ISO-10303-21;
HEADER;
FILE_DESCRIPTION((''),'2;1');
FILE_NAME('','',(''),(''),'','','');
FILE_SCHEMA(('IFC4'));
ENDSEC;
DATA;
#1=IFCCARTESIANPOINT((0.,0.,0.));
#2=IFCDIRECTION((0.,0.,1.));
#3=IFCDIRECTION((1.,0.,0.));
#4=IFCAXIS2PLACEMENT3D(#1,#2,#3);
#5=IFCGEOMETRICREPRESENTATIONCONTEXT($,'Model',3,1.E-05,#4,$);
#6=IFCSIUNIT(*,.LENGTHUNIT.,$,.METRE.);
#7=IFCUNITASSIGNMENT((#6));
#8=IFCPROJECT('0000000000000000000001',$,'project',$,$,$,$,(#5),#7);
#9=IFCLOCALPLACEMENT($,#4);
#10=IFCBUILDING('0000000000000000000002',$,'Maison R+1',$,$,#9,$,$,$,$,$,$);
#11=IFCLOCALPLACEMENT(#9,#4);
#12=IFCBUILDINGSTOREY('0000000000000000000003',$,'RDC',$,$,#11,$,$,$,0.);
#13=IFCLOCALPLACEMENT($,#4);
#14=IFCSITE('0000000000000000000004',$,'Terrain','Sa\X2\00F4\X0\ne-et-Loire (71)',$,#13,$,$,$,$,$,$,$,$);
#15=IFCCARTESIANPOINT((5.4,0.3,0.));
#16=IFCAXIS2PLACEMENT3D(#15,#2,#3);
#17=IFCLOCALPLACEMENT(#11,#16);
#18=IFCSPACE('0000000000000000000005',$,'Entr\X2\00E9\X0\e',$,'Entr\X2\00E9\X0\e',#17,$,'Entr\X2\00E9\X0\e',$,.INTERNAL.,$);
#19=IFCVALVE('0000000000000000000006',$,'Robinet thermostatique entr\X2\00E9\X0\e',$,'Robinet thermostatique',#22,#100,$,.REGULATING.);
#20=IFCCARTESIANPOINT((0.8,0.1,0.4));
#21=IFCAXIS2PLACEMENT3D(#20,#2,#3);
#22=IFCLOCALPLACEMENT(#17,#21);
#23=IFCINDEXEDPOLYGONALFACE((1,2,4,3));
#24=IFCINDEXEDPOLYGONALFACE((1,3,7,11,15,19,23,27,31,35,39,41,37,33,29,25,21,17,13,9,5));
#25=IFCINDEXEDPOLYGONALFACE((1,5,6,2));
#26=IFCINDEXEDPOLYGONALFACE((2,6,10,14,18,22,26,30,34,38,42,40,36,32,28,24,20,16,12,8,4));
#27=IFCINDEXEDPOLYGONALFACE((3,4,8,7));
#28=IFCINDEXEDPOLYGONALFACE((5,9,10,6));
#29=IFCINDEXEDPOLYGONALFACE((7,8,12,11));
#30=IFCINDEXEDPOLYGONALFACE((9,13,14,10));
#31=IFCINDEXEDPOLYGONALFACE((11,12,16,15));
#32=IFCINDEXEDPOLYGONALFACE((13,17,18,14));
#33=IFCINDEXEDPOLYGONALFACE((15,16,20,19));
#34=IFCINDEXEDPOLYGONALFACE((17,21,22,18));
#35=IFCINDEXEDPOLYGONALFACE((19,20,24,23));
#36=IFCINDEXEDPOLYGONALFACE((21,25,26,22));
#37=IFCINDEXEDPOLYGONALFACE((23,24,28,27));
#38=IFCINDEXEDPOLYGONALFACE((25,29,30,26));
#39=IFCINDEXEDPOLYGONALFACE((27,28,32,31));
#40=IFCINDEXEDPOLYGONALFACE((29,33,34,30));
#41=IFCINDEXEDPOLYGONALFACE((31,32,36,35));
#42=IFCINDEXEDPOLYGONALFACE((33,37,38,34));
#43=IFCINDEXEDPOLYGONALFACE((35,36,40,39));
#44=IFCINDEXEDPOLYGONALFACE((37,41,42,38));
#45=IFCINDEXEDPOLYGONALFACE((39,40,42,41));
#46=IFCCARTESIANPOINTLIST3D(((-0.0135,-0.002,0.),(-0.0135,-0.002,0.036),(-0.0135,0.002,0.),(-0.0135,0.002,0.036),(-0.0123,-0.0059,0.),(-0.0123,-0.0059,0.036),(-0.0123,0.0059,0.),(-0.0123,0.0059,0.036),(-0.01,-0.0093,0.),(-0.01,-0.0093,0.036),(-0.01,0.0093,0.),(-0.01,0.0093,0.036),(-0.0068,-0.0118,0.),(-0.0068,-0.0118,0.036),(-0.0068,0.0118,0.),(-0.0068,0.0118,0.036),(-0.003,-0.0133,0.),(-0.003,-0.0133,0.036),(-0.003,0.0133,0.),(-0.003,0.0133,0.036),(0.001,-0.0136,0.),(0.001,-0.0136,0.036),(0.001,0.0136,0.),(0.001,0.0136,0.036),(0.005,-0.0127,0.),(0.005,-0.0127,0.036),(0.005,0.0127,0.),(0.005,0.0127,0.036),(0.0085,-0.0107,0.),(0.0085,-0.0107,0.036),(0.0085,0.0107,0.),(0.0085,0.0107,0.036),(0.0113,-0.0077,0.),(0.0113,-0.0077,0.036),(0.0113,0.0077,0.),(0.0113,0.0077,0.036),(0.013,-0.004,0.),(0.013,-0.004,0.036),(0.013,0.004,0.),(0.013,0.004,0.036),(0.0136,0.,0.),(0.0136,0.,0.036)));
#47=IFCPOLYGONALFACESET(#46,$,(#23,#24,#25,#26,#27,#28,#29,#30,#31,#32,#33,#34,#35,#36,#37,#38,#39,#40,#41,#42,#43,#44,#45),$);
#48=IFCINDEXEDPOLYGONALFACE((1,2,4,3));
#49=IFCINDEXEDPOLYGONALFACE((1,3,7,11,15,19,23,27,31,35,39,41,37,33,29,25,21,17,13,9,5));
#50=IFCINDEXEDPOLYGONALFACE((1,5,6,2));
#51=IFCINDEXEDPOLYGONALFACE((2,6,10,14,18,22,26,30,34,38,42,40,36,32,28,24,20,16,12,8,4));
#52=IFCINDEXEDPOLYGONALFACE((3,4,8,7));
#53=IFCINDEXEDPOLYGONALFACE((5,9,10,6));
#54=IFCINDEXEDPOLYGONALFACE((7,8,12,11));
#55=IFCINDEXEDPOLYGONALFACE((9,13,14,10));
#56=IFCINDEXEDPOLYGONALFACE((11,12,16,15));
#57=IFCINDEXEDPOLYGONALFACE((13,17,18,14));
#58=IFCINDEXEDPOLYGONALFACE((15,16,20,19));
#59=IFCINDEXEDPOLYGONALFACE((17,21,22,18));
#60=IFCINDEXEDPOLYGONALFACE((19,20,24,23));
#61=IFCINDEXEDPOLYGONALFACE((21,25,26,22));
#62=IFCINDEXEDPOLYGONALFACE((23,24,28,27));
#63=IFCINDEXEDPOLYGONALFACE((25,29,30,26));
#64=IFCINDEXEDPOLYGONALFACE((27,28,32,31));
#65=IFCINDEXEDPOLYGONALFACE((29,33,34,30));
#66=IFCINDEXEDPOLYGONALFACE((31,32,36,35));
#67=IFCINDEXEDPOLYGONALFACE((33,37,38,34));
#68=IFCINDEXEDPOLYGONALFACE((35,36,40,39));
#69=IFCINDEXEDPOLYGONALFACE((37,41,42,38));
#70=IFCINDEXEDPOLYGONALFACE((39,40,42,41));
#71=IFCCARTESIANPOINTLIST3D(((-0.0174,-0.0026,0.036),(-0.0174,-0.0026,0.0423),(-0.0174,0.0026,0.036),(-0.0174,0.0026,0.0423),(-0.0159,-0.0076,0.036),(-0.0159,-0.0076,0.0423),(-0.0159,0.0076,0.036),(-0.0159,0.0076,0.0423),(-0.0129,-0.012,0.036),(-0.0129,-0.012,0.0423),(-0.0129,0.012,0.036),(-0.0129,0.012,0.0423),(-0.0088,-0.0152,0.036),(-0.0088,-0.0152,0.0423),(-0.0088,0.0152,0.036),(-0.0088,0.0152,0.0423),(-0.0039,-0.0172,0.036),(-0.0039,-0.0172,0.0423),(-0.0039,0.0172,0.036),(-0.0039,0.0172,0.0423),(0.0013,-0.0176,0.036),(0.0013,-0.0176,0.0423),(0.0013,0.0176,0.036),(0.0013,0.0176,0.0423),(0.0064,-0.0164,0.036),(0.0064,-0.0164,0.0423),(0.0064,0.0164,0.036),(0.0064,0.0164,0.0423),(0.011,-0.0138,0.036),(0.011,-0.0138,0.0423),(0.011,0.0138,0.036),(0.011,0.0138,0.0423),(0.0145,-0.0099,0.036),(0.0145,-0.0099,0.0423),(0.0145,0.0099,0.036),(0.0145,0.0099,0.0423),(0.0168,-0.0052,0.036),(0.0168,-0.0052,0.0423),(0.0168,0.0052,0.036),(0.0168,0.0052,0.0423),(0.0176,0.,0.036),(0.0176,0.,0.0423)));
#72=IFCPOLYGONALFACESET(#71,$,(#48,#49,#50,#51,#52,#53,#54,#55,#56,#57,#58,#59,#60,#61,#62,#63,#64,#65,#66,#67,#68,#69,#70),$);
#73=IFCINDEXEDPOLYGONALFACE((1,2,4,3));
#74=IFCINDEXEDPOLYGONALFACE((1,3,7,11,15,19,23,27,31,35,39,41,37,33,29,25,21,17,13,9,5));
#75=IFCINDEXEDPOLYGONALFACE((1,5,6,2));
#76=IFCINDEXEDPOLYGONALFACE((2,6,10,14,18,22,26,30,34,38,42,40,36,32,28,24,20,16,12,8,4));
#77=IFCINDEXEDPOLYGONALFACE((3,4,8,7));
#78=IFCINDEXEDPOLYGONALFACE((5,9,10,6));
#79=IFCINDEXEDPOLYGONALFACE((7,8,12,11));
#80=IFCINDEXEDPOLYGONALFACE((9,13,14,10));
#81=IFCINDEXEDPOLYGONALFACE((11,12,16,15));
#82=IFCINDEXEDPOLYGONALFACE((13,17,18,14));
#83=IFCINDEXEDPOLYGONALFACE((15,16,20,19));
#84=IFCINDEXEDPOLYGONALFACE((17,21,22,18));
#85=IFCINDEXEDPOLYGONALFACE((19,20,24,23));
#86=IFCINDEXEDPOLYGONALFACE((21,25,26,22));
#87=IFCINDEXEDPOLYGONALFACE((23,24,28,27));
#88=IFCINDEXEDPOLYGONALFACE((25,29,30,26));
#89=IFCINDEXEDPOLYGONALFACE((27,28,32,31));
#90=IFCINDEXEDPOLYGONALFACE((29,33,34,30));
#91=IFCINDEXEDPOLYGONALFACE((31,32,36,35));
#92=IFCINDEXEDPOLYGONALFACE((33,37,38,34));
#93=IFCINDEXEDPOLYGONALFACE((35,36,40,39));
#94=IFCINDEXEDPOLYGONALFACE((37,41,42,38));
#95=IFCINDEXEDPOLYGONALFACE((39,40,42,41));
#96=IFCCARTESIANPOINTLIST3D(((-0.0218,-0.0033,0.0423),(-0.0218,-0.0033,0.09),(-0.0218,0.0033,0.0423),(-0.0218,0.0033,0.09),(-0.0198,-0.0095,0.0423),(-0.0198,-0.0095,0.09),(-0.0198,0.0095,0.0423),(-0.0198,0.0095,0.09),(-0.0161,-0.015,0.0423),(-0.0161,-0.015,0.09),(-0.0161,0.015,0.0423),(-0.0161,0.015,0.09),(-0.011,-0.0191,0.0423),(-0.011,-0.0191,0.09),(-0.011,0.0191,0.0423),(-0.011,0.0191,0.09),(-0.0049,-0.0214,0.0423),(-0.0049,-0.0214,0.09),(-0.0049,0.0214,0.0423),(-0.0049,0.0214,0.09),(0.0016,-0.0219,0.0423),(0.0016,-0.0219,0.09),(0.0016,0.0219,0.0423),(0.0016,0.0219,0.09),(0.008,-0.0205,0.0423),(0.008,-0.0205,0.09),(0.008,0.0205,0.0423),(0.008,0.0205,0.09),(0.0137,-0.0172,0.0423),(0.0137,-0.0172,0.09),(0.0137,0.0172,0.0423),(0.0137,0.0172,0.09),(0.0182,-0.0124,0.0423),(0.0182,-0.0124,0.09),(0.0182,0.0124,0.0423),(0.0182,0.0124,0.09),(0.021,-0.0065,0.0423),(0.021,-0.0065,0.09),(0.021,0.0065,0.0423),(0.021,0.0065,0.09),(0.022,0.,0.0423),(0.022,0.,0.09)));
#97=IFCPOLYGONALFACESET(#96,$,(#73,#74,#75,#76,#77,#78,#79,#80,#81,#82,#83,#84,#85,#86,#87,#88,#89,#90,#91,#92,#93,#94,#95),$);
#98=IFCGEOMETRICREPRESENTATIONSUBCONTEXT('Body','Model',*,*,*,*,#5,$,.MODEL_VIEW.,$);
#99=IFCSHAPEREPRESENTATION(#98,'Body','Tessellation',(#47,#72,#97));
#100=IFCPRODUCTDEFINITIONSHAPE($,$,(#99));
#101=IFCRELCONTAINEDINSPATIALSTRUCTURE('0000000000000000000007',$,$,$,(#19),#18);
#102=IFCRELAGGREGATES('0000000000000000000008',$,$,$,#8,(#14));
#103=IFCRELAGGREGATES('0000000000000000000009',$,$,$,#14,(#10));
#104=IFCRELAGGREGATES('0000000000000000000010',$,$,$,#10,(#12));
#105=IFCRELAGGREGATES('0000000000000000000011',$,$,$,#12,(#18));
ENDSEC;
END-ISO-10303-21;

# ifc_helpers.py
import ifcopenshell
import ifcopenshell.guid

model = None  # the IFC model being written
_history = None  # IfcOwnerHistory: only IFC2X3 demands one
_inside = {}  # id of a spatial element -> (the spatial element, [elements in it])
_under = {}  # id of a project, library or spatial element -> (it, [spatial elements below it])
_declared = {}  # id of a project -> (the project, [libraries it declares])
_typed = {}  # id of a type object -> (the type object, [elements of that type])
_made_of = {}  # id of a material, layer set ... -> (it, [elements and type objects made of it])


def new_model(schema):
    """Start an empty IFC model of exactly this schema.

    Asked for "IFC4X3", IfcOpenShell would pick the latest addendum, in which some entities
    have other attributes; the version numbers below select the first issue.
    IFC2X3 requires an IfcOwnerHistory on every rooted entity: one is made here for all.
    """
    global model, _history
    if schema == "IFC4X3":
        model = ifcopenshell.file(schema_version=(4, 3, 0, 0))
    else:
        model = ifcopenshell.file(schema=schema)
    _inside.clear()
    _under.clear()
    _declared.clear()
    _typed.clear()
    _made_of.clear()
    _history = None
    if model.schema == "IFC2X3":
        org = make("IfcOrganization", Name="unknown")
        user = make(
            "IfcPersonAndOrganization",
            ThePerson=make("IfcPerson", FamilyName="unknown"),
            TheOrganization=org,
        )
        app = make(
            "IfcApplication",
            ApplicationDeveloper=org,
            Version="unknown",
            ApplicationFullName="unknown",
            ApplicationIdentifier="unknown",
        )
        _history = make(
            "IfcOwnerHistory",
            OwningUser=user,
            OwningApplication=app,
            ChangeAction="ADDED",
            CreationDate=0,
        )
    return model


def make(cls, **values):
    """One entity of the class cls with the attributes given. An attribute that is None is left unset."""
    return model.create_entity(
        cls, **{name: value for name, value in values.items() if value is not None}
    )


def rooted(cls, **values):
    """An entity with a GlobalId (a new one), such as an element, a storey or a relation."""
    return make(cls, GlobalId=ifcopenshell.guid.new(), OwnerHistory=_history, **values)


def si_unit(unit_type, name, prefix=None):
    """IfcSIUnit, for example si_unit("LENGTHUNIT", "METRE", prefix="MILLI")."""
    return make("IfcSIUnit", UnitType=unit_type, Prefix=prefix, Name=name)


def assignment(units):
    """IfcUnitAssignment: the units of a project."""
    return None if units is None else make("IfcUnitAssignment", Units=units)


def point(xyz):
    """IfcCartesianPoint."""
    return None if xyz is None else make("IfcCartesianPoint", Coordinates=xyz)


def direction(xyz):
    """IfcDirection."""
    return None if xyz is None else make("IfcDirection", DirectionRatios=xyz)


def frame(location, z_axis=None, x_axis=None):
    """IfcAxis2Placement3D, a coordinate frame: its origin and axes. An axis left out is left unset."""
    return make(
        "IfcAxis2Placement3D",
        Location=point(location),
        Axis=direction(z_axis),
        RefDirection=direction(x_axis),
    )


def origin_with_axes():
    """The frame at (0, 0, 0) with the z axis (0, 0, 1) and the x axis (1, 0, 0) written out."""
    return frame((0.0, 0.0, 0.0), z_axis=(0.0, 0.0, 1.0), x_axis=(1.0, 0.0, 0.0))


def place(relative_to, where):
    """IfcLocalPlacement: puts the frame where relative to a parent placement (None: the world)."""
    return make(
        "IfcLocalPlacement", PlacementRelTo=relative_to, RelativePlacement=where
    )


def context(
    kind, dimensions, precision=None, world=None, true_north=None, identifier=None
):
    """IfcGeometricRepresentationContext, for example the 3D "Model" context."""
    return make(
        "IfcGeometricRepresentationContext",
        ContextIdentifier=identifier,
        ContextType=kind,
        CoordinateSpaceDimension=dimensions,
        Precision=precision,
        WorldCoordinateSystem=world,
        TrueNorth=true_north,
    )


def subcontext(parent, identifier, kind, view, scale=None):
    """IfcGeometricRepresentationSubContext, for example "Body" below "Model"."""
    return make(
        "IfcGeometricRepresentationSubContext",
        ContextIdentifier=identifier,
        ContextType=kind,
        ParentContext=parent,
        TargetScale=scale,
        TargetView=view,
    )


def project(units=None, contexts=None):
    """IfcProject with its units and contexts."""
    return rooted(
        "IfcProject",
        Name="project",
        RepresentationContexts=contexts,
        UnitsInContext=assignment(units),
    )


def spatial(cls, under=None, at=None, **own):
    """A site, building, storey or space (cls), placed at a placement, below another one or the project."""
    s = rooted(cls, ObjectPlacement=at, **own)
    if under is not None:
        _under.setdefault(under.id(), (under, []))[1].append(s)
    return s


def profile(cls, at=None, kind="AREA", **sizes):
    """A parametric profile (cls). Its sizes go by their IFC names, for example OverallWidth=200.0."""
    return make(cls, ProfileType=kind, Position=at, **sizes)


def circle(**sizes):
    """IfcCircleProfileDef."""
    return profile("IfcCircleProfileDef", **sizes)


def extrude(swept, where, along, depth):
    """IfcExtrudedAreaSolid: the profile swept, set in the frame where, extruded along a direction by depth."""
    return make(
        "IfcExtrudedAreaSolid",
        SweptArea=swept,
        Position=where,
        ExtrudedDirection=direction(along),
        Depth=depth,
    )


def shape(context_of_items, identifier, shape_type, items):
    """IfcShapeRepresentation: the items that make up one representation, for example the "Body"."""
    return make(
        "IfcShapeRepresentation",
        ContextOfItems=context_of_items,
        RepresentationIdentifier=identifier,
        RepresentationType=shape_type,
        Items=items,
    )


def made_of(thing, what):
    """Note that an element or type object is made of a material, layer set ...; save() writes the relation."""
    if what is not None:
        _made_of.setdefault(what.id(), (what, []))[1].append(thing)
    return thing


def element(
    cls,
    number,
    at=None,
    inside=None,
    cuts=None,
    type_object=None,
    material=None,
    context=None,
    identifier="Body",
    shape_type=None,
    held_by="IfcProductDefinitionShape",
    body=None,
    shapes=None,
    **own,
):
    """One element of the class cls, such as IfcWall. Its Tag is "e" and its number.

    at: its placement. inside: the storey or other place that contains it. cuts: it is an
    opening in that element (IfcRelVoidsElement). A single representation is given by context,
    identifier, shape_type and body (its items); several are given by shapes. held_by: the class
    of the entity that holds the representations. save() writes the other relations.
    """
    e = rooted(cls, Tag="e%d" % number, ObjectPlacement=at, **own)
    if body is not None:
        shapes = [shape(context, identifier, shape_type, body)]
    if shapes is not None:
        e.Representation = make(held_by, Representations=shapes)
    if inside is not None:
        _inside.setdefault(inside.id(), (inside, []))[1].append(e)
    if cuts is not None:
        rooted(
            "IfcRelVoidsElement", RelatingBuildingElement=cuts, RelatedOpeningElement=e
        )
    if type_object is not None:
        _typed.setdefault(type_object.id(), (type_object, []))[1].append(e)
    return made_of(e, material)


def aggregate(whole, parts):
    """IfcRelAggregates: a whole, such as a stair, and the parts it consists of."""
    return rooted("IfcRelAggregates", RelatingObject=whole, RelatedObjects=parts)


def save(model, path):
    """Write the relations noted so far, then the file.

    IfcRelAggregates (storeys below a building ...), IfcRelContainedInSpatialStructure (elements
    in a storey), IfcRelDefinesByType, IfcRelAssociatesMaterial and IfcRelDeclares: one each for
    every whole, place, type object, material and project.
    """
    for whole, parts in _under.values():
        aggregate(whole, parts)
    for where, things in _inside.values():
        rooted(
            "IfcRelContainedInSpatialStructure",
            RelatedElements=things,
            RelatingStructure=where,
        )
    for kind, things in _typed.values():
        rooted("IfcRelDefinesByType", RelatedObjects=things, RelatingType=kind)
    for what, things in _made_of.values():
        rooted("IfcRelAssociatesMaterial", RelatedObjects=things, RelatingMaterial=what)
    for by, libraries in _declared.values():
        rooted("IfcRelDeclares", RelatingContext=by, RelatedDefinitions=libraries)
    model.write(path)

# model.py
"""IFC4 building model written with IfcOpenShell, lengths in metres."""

from ifc_helpers import new_model, si_unit, frame, origin_with_axes, place, context, subcontext, project, spatial, circle, extrude, element, save


model = new_model("IFC4")

# Units and contexts
model_context = context("Model", 3, precision=1e-05, world=origin_with_axes())
body_context = subcontext(model_context, "Body", "Model", "MODEL_VIEW")
ifc_project = project(units=[si_unit("LENGTHUNIT", "METRE")], contexts=[model_context])

# Site, building, storey
site_placement = place(None, origin_with_axes())
site = spatial("IfcSite", under=ifc_project, at=site_placement, Name="Terrain", Description="Saône-et-Loire (71)")
building_placement = place(None, origin_with_axes())
building = spatial("IfcBuilding", under=site, at=building_placement, Name="Maison R+1")
storey_placement = place(building_placement, origin_with_axes())
storey = spatial("IfcBuildingStorey", under=building, at=storey_placement, Name="RDC", Elevation=0.0)

# Shared definitions
space_placement = place(storey_placement, frame((5.4, 0.3, 0.0), z_axis=(0.0, 0.0, 1.0), x_axis=(1.0, 0.0, 0.0)))
space = spatial("IfcSpace", under=storey, at=space_placement, Name="Entrée", ObjectType="Entrée", LongName="Entrée", PredefinedType="INTERNAL")

# Valve
valve_1_placement = place(space_placement, frame((0.8, 0.1, 0.4), z_axis=(0.0, 0.0, 1.0), x_axis=(1.0, 0.0, 0.0)))
element("IfcValve", 1, at=valve_1_placement, inside=space, Name="Robinet thermostatique entrée", ObjectType="Robinet thermostatique", PredefinedType="REGULATING", context=body_context, shape_type="SweptSolid", body=[
    extrude(circle(Radius=0.0136), origin_with_axes(), (0.0, 0.0, 1.0), 0.036),
    extrude(circle(Radius=0.0176), frame((0.0, 0.0, 0.036), z_axis=(0.0, 0.0, 1.0), x_axis=(1.0, 0.0, 0.0)), (0.0, 0.0, 1.0), 0.0063),
    extrude(circle(Radius=0.022), frame((0.0, 0.0, 0.0423), z_axis=(0.0, 0.0, 1.0), x_axis=(1.0, 0.0, 0.0)), (0.0, 0.0, 1.0), 0.0477),
])

save(model, "model.ifc")
